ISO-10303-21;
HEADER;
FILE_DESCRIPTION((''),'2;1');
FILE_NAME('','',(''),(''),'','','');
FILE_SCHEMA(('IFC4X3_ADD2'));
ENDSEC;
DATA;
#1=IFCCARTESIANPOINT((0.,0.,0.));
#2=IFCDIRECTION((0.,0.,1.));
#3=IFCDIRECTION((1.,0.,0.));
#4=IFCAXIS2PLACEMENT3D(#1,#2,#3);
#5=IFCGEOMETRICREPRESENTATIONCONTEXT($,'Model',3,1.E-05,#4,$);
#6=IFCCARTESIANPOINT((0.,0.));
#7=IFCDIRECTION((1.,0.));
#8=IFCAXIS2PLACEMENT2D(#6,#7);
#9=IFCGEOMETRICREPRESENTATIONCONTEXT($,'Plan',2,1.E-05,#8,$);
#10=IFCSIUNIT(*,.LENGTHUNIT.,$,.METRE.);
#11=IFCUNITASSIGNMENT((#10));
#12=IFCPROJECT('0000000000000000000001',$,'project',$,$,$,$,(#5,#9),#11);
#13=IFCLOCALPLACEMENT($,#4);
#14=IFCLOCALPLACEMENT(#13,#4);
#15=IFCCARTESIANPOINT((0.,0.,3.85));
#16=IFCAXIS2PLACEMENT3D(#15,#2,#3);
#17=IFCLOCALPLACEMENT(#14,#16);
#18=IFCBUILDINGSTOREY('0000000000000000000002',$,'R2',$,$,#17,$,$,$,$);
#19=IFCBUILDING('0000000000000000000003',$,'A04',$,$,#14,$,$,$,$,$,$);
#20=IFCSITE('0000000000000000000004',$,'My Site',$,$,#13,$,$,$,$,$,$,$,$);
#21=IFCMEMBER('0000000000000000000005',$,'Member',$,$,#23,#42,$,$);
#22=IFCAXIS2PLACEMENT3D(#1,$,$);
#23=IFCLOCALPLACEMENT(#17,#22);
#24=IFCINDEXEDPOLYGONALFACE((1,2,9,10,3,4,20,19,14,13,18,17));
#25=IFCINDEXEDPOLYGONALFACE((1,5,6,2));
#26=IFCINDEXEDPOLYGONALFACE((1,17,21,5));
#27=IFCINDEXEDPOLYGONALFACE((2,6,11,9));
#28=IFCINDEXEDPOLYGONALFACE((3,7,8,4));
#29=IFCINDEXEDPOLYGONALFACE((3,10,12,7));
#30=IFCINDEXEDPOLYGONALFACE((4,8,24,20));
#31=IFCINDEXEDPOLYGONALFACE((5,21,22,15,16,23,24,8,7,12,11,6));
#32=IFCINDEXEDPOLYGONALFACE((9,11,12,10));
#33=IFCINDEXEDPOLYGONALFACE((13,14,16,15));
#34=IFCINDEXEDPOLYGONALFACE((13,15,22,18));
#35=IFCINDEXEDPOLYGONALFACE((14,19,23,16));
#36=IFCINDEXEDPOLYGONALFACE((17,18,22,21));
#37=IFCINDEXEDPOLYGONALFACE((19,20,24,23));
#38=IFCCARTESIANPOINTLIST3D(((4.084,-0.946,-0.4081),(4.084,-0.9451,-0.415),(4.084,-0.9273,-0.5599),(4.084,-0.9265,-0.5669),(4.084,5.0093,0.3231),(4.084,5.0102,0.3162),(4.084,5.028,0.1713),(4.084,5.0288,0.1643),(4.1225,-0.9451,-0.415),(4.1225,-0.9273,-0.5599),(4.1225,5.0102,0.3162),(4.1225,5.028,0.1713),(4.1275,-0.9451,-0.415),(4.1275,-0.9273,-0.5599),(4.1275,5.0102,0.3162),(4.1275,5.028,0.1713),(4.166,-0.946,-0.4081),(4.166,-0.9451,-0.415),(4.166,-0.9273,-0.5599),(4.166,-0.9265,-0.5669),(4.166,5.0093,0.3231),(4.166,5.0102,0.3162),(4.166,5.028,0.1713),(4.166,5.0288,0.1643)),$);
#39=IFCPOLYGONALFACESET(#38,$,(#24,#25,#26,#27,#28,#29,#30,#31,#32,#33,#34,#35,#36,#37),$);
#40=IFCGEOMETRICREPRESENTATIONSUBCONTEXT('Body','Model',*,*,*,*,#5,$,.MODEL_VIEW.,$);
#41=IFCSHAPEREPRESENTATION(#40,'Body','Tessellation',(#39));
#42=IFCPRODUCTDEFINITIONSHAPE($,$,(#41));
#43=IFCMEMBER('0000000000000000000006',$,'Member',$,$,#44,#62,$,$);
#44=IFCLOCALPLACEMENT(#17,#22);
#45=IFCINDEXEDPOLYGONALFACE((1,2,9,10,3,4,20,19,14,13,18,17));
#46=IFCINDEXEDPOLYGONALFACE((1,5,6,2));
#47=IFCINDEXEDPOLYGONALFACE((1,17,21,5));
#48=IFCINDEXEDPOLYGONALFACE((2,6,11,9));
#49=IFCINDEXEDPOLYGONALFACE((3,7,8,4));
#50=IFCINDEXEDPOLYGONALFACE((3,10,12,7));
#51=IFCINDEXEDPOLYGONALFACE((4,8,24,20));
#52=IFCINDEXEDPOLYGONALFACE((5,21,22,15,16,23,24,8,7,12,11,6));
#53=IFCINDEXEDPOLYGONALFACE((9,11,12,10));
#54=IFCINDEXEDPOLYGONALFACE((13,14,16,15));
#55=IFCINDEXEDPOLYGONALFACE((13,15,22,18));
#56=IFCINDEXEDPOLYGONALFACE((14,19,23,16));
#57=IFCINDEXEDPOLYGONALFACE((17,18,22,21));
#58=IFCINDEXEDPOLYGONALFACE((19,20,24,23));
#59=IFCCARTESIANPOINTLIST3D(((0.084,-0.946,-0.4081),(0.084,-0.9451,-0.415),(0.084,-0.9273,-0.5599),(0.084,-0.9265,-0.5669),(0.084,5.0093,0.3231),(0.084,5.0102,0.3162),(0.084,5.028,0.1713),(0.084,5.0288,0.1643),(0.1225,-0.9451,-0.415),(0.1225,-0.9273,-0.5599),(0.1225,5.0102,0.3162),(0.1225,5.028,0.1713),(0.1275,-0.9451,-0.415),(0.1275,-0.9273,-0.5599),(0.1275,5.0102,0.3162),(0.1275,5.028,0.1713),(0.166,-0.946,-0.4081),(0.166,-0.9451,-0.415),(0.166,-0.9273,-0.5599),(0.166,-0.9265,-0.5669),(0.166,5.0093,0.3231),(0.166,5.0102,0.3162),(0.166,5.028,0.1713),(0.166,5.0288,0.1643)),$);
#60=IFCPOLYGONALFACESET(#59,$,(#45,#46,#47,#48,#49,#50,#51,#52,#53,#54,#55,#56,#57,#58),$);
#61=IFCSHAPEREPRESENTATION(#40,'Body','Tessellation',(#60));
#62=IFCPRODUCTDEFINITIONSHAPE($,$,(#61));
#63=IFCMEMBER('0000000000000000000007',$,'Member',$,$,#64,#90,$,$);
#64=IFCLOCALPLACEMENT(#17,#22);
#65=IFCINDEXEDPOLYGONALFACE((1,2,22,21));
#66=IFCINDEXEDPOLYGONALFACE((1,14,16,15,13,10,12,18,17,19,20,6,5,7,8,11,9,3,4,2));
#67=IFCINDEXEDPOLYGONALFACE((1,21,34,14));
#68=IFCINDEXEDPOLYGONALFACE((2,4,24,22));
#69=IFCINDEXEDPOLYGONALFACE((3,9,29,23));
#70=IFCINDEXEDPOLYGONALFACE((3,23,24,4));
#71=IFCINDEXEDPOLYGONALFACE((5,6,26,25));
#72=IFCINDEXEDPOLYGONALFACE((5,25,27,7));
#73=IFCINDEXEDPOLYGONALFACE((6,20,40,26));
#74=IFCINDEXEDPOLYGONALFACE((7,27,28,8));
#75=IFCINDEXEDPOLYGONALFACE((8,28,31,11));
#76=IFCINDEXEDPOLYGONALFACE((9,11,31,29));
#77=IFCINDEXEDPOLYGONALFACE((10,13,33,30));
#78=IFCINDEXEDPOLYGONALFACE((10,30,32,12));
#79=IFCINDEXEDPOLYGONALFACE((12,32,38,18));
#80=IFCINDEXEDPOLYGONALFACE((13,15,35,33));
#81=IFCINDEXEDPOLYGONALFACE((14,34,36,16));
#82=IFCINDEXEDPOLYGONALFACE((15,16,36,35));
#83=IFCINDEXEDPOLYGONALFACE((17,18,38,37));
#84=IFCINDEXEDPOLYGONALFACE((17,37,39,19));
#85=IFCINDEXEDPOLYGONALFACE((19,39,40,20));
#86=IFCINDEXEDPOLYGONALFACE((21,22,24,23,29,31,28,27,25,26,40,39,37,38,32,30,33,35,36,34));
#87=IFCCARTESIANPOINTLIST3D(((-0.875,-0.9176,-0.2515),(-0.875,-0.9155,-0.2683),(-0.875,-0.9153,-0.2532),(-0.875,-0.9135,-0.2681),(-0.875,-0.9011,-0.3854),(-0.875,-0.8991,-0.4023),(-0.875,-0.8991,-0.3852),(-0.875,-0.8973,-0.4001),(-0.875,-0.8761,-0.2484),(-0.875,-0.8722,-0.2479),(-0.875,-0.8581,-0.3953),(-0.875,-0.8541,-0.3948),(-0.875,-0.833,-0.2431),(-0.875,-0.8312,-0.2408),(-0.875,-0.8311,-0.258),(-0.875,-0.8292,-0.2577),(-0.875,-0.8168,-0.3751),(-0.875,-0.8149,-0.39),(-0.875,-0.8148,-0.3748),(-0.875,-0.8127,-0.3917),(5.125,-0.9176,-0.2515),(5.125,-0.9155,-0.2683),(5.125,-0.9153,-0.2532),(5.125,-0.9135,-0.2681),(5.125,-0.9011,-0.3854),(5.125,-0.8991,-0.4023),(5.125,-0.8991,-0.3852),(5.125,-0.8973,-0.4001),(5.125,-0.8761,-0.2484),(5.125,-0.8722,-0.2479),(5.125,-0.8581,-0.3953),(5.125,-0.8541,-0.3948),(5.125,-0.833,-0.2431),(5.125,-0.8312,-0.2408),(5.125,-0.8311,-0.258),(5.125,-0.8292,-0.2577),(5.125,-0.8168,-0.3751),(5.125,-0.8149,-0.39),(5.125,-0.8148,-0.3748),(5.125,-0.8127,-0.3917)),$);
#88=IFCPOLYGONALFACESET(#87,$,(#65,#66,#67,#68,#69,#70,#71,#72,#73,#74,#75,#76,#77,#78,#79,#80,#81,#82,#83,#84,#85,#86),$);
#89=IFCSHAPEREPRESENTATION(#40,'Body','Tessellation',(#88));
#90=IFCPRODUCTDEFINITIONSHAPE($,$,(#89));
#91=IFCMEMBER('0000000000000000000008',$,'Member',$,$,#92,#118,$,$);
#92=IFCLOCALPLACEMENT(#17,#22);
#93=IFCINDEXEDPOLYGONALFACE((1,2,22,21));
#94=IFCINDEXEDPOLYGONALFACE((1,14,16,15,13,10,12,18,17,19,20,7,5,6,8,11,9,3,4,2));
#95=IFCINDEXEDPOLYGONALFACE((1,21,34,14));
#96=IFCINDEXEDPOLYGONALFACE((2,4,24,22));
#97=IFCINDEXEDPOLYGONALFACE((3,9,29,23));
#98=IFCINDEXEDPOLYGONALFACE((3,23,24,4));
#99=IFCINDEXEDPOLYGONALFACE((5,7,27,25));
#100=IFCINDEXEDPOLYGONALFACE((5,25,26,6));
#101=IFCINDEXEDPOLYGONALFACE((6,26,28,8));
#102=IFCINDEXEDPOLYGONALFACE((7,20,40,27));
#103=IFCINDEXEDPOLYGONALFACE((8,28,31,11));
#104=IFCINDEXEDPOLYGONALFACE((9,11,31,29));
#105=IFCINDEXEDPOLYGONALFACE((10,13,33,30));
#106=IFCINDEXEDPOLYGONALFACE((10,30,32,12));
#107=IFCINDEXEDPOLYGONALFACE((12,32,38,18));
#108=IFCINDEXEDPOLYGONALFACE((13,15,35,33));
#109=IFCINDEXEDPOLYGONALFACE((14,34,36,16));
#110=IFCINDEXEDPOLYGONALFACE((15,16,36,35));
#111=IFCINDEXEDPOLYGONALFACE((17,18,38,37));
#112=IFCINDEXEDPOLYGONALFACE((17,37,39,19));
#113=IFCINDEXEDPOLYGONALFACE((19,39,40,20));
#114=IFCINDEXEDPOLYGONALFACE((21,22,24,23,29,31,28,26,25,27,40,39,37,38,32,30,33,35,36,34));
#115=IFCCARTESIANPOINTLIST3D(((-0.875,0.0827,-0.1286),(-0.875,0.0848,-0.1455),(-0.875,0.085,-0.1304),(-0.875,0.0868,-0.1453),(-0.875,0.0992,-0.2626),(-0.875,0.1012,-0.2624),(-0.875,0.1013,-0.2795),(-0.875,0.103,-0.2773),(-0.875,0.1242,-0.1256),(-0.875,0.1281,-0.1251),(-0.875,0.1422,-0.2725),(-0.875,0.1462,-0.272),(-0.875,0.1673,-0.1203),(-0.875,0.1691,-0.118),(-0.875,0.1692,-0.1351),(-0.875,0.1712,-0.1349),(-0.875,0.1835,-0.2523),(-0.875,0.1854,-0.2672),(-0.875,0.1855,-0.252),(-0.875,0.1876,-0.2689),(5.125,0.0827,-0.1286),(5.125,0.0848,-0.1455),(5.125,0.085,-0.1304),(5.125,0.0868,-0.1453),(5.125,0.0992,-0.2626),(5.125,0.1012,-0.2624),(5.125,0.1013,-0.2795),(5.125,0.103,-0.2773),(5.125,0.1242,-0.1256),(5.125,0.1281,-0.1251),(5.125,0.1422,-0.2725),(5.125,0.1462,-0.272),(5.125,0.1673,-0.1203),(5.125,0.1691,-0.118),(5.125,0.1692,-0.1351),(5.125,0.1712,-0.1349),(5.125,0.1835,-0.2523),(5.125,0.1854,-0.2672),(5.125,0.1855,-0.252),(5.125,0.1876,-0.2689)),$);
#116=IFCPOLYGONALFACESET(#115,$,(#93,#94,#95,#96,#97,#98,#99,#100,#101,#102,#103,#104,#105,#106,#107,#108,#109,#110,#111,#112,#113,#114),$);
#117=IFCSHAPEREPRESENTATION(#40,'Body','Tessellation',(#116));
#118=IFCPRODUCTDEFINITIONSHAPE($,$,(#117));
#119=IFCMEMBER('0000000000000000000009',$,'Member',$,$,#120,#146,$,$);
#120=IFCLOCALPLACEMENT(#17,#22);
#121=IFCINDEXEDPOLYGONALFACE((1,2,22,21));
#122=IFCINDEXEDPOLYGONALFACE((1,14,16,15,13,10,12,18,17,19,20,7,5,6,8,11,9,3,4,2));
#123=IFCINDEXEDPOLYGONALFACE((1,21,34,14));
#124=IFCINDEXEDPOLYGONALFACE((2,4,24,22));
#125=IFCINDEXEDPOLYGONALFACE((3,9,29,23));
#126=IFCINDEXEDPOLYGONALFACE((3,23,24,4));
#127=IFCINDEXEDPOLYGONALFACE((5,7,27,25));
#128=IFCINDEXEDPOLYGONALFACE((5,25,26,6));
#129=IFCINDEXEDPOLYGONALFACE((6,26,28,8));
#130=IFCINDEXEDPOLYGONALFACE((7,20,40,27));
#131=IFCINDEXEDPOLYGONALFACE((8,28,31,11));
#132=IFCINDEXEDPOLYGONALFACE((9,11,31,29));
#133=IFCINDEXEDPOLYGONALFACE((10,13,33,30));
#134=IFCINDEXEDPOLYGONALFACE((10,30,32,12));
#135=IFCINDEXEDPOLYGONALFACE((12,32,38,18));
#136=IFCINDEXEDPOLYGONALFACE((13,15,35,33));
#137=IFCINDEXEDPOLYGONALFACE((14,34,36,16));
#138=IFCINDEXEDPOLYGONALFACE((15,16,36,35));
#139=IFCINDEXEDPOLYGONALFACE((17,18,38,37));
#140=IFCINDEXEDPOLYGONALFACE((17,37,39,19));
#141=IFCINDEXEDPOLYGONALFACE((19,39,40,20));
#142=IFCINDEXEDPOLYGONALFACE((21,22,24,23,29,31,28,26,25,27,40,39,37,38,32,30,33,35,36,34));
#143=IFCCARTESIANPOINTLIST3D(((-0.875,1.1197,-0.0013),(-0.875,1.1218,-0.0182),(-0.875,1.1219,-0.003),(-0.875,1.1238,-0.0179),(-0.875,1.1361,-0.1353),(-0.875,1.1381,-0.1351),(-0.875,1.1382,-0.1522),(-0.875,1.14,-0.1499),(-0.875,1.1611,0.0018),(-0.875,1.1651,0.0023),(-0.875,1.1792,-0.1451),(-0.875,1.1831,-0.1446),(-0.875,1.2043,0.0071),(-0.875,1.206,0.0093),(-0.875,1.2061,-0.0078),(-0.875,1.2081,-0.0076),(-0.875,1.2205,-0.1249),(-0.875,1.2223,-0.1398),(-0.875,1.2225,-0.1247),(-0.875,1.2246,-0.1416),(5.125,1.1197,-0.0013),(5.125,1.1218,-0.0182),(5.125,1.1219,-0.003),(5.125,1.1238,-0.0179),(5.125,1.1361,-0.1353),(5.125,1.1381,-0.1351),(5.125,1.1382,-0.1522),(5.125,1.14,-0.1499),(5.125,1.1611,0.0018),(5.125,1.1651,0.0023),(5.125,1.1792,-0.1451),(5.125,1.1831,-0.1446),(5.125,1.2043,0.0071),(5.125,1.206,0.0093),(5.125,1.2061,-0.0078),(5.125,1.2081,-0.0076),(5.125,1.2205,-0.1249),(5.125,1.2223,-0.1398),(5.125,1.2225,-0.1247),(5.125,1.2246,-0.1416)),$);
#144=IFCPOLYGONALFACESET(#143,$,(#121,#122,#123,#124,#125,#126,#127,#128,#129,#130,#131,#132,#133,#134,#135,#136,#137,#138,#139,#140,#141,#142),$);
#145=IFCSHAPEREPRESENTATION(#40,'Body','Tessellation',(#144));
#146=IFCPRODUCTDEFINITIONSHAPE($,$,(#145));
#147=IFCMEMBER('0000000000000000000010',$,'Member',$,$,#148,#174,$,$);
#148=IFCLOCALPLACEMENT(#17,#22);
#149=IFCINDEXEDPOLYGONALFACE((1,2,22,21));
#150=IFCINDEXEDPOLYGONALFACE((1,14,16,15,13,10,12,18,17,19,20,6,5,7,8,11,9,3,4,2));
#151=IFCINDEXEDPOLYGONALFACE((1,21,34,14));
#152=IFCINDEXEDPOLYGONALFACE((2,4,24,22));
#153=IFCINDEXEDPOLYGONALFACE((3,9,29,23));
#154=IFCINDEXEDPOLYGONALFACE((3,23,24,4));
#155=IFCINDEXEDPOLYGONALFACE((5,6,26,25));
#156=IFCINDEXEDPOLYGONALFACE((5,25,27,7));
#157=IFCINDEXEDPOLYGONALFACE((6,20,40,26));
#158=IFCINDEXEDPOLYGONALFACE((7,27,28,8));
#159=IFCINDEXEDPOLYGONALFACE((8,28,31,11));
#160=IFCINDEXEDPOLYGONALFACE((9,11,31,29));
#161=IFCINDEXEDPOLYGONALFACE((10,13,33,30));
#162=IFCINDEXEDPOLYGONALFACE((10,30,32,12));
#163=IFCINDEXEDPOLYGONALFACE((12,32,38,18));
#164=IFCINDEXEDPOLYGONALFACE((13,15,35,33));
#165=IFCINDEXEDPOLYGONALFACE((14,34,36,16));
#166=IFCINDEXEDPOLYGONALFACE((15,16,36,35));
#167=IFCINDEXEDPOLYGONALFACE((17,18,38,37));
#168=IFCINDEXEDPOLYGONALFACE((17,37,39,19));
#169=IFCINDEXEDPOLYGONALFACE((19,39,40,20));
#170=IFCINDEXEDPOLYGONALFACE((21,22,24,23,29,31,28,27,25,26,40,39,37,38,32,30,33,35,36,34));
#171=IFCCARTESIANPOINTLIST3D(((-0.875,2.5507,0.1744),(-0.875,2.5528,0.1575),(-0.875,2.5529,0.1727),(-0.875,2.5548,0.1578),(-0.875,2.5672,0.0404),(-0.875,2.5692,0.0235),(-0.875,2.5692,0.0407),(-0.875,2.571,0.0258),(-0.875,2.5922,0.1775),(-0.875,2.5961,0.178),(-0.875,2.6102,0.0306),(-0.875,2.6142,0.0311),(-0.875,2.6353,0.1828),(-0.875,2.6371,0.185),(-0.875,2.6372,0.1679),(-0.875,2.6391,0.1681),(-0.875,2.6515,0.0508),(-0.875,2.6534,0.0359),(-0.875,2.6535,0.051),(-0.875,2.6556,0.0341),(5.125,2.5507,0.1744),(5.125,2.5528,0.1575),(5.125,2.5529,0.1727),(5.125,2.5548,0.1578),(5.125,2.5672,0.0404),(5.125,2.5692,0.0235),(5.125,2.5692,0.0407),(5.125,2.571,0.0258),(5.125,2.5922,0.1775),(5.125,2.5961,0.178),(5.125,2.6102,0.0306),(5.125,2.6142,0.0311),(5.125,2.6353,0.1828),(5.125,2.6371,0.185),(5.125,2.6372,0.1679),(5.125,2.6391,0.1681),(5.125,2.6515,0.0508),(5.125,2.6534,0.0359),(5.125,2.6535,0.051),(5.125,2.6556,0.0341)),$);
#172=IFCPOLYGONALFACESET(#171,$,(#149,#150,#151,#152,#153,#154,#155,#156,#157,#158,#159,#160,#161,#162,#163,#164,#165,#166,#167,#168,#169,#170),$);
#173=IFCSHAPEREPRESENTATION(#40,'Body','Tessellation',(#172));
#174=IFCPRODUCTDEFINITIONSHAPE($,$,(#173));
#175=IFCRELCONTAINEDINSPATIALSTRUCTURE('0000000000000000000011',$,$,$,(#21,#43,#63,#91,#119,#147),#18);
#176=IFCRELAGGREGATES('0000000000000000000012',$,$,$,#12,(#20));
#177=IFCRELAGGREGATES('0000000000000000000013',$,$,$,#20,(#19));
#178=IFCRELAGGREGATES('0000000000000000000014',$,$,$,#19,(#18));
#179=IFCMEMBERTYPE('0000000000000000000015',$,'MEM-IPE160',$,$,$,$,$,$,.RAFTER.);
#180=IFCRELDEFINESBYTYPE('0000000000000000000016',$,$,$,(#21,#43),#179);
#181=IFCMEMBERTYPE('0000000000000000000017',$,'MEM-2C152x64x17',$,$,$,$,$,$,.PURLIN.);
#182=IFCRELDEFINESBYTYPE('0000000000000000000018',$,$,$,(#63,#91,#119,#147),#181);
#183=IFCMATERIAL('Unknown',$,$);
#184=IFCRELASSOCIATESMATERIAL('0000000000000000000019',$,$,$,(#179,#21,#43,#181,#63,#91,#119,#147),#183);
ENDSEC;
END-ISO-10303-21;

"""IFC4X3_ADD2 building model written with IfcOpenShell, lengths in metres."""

from ifc_helpers import new_model, si_unit, frame, origin_with_axes, origin_2d_with_axis, place, context, subcontext, project, spatial, indexed_curve, i_section, outline, extrude, material, material_profile, profile_set, profile_usage, type_object, element, save


model = new_model("IFC4X3_ADD2")

# Units and contexts
model_context = context("Model", 3, precision=1e-05, world=origin_with_axes())
plan_context = context("Plan", 2, precision=1e-05, world=origin_2d_with_axis())
body_context = subcontext(model_context, "Body", "Model", "MODEL_VIEW")
ifc_project = project(units=[si_unit("LENGTHUNIT", "METRE")], contexts=[model_context, plan_context])

# Site, building, storey
site_placement = place(None, origin_with_axes())
site = spatial("IfcSite", under=ifc_project, at=site_placement, Name="My Site")
building_placement = place(site_placement, origin_with_axes())
building = spatial("IfcBuilding", under=site, at=building_placement, Name="A04")
storey_placement = place(building_placement, frame((0.0, 0.0, 3.85), z_axis=(0.0, 0.0, 1.0), x_axis=(1.0, 0.0, 0.0)))
storey = spatial("IfcBuildingStorey", under=building, at=storey_placement, Name="R2")

# Members
ifc_material_1 = material(Name="Unknown")
ifc_material_profile_1 = material_profile(ifc_material_1, i_section(OverallWidth=0.082, OverallDepth=0.16, WebThickness=0.005, FlangeThickness=0.007, FilletRadius=0.0))
ifc_profile_set_1 = profile_set([ifc_material_profile_1])
ifc_profile_usage_1 = profile_usage(ifc_profile_set_1, cardinal=2)
member_type_1 = type_object("IfcMemberType", Name="MEM-IPE160", PredefinedType="RAFTER", material=ifc_profile_set_1)
member_1_placement = place(storey_placement, frame((4.125, -0.9265, -0.5669), z_axis=(0.0, 0.992546, 0.121869), x_axis=(-1.0, 0.0, 0.0)))
element("IfcMember", 1, at=member_1_placement, inside=storey, type_object=member_type_1, material=ifc_profile_usage_1, Name="Member", context=body_context, shape_type="SweptSolid", body=[
    extrude(i_section(OverallWidth=0.082, OverallDepth=0.16, WebThickness=0.005, FlangeThickness=0.007, FilletRadius=0.0), frame((0.0, 0.08, 0.0), z_axis=(0.0, 0.0, 1.0), x_axis=(1.0, 0.0, 0.0)), (0.0, 0.0, 1.0), 6.0),
])
ifc_profile_usage_2 = profile_usage(ifc_profile_set_1, cardinal=2)
member_2_placement = place(storey_placement, frame((0.125, -0.9265, -0.5669), z_axis=(0.0, 0.992546, 0.121869), x_axis=(-1.0, 0.0, 0.0)))
element("IfcMember", 2, at=member_2_placement, inside=storey, type_object=member_type_1, material=ifc_profile_usage_2, Name="Member", context=body_context, shape_type="SweptSolid", body=[
    extrude(i_section(OverallWidth=0.082, OverallDepth=0.16, WebThickness=0.005, FlangeThickness=0.007, FilletRadius=0.0), frame((0.0, 0.08, 0.0), z_axis=(0.0, 0.0, 1.0), x_axis=(1.0, 0.0, 0.0)), (0.0, 0.0, 1.0), 6.0),
])
ifc_material_profile_2 = material_profile(ifc_material_1, outline(indexed_curve([(-0.0435, 0.017), (-0.0435, 0.0), (0.0435, 0.0), (0.0435, 0.017), (0.0415, 0.017), (0.0415, 0.002), (0.002, 0.002), (0.002, 0.15), (0.0415, 0.15), (0.0415, 0.135), (0.0435, 0.135), (0.0435, 0.152), (-0.0435, 0.152), (-0.0435, 0.135), (-0.0415, 0.135), (-0.0415, 0.15), (-0.002, 0.15), (-0.002, 0.002), (-0.0415, 0.002), (-0.0415, 0.017), (-0.0435, 0.017)])))
ifc_profile_set_2 = profile_set([ifc_material_profile_2])
ifc_profile_usage_3 = profile_usage(ifc_profile_set_2, cardinal=5)
member_type_2 = type_object("IfcMemberType", Name="MEM-2C152x64x17", PredefinedType="PURLIN", material=ifc_profile_set_2)
member_3_placement = place(storey_placement, frame((5.125, -0.8559, -0.397), z_axis=(-1.0, 0.0, 0.0), x_axis=(0.0, -0.992546, -0.121869)))
element("IfcMember", 3, at=member_3_placement, inside=storey, type_object=member_type_2, material=ifc_profile_usage_3, Name="Member", context=body_context, shape_type="SweptSolid", body=[
    extrude(outline(indexed_curve([(-0.0435, 0.017), (-0.0435, 0.0), (0.0435, 0.0), (0.0435, 0.017), (0.0415, 0.017), (0.0415, 0.002), (0.002, 0.002), (0.002, 0.15), (0.0415, 0.15), (0.0415, 0.135), (0.0435, 0.135), (0.0435, 0.152), (-0.0435, 0.152), (-0.0435, 0.135), (-0.0415, 0.135), (-0.0415, 0.15), (-0.002, 0.15), (-0.002, 0.002), (-0.0415, 0.002), (-0.0415, 0.017), (-0.0435, 0.017)])), origin_with_axes(), (0.0, 0.0, 1.0), 6.0),
])
ifc_profile_usage_4 = profile_usage(ifc_profile_set_2, cardinal=5)
member_4_placement = place(storey_placement, frame((5.125, 0.1444, -0.2742), z_axis=(-1.0, 0.0, 0.0), x_axis=(0.0, -0.992546, -0.121869)))
element("IfcMember", 4, at=member_4_placement, inside=storey, type_object=member_type_2, material=ifc_profile_usage_4, Name="Member", context=body_context, shape_type="SweptSolid", body=[
    extrude(outline(indexed_curve([(-0.0435, 0.017), (-0.0435, 0.0), (0.0435, 0.0), (0.0435, 0.017), (0.0415, 0.017), (0.0415, 0.002), (0.002, 0.002), (0.002, 0.15), (0.0415, 0.15), (0.0415, 0.135), (0.0435, 0.135), (0.0435, 0.152), (-0.0435, 0.152), (-0.0435, 0.135), (-0.0415, 0.135), (-0.0415, 0.15), (-0.002, 0.15), (-0.002, 0.002), (-0.0415, 0.002), (-0.0415, 0.017), (-0.0435, 0.017)])), origin_with_axes(), (0.0, 0.0, 1.0), 6.0),
])
ifc_profile_usage_5 = profile_usage(ifc_profile_set_2, cardinal=5)
member_5_placement = place(storey_placement, frame((5.125, 1.1814, -0.1469), z_axis=(-1.0, 0.0, 0.0), x_axis=(0.0, -0.992546, -0.121869)))
element("IfcMember", 5, at=member_5_placement, inside=storey, type_object=member_type_2, material=ifc_profile_usage_5, Name="Member", context=body_context, shape_type="SweptSolid", body=[
    extrude(outline(indexed_curve([(-0.0435, 0.017), (-0.0435, 0.0), (0.0435, 0.0), (0.0435, 0.017), (0.0415, 0.017), (0.0415, 0.002), (0.002, 0.002), (0.002, 0.15), (0.0415, 0.15), (0.0415, 0.135), (0.0435, 0.135), (0.0435, 0.152), (-0.0435, 0.152), (-0.0435, 0.135), (-0.0415, 0.135), (-0.0415, 0.15), (-0.002, 0.15), (-0.002, 0.002), (-0.0415, 0.002), (-0.0415, 0.017), (-0.0435, 0.017)])), origin_with_axes(), (0.0, 0.0, 1.0), 6.0),
])
ifc_profile_usage_6 = profile_usage(ifc_profile_set_2, cardinal=5)
member_6_placement = place(storey_placement, frame((5.125, 2.6124, 0.0288), z_axis=(-1.0, 0.0, 0.0), x_axis=(0.0, -0.992546, -0.121869)))
element("IfcMember", 6, at=member_6_placement, inside=storey, type_object=member_type_2, material=ifc_profile_usage_6, Name="Member", context=body_context, shape_type="SweptSolid", body=[
    extrude(outline(indexed_curve([(-0.0435, 0.017), (-0.0435, 0.0), (0.0435, 0.0), (0.0435, 0.017), (0.0415, 0.017), (0.0415, 0.002), (0.002, 0.002), (0.002, 0.15), (0.0415, 0.15), (0.0415, 0.135), (0.0435, 0.135), (0.0435, 0.152), (-0.0435, 0.152), (-0.0435, 0.135), (-0.0415, 0.135), (-0.0415, 0.15), (-0.002, 0.15), (-0.002, 0.002), (-0.0415, 0.002), (-0.0415, 0.017), (-0.0435, 0.017)])), origin_with_axes(), (0.0, 0.0, 1.0), 6.0),
])

save(model, "model.ifc")
